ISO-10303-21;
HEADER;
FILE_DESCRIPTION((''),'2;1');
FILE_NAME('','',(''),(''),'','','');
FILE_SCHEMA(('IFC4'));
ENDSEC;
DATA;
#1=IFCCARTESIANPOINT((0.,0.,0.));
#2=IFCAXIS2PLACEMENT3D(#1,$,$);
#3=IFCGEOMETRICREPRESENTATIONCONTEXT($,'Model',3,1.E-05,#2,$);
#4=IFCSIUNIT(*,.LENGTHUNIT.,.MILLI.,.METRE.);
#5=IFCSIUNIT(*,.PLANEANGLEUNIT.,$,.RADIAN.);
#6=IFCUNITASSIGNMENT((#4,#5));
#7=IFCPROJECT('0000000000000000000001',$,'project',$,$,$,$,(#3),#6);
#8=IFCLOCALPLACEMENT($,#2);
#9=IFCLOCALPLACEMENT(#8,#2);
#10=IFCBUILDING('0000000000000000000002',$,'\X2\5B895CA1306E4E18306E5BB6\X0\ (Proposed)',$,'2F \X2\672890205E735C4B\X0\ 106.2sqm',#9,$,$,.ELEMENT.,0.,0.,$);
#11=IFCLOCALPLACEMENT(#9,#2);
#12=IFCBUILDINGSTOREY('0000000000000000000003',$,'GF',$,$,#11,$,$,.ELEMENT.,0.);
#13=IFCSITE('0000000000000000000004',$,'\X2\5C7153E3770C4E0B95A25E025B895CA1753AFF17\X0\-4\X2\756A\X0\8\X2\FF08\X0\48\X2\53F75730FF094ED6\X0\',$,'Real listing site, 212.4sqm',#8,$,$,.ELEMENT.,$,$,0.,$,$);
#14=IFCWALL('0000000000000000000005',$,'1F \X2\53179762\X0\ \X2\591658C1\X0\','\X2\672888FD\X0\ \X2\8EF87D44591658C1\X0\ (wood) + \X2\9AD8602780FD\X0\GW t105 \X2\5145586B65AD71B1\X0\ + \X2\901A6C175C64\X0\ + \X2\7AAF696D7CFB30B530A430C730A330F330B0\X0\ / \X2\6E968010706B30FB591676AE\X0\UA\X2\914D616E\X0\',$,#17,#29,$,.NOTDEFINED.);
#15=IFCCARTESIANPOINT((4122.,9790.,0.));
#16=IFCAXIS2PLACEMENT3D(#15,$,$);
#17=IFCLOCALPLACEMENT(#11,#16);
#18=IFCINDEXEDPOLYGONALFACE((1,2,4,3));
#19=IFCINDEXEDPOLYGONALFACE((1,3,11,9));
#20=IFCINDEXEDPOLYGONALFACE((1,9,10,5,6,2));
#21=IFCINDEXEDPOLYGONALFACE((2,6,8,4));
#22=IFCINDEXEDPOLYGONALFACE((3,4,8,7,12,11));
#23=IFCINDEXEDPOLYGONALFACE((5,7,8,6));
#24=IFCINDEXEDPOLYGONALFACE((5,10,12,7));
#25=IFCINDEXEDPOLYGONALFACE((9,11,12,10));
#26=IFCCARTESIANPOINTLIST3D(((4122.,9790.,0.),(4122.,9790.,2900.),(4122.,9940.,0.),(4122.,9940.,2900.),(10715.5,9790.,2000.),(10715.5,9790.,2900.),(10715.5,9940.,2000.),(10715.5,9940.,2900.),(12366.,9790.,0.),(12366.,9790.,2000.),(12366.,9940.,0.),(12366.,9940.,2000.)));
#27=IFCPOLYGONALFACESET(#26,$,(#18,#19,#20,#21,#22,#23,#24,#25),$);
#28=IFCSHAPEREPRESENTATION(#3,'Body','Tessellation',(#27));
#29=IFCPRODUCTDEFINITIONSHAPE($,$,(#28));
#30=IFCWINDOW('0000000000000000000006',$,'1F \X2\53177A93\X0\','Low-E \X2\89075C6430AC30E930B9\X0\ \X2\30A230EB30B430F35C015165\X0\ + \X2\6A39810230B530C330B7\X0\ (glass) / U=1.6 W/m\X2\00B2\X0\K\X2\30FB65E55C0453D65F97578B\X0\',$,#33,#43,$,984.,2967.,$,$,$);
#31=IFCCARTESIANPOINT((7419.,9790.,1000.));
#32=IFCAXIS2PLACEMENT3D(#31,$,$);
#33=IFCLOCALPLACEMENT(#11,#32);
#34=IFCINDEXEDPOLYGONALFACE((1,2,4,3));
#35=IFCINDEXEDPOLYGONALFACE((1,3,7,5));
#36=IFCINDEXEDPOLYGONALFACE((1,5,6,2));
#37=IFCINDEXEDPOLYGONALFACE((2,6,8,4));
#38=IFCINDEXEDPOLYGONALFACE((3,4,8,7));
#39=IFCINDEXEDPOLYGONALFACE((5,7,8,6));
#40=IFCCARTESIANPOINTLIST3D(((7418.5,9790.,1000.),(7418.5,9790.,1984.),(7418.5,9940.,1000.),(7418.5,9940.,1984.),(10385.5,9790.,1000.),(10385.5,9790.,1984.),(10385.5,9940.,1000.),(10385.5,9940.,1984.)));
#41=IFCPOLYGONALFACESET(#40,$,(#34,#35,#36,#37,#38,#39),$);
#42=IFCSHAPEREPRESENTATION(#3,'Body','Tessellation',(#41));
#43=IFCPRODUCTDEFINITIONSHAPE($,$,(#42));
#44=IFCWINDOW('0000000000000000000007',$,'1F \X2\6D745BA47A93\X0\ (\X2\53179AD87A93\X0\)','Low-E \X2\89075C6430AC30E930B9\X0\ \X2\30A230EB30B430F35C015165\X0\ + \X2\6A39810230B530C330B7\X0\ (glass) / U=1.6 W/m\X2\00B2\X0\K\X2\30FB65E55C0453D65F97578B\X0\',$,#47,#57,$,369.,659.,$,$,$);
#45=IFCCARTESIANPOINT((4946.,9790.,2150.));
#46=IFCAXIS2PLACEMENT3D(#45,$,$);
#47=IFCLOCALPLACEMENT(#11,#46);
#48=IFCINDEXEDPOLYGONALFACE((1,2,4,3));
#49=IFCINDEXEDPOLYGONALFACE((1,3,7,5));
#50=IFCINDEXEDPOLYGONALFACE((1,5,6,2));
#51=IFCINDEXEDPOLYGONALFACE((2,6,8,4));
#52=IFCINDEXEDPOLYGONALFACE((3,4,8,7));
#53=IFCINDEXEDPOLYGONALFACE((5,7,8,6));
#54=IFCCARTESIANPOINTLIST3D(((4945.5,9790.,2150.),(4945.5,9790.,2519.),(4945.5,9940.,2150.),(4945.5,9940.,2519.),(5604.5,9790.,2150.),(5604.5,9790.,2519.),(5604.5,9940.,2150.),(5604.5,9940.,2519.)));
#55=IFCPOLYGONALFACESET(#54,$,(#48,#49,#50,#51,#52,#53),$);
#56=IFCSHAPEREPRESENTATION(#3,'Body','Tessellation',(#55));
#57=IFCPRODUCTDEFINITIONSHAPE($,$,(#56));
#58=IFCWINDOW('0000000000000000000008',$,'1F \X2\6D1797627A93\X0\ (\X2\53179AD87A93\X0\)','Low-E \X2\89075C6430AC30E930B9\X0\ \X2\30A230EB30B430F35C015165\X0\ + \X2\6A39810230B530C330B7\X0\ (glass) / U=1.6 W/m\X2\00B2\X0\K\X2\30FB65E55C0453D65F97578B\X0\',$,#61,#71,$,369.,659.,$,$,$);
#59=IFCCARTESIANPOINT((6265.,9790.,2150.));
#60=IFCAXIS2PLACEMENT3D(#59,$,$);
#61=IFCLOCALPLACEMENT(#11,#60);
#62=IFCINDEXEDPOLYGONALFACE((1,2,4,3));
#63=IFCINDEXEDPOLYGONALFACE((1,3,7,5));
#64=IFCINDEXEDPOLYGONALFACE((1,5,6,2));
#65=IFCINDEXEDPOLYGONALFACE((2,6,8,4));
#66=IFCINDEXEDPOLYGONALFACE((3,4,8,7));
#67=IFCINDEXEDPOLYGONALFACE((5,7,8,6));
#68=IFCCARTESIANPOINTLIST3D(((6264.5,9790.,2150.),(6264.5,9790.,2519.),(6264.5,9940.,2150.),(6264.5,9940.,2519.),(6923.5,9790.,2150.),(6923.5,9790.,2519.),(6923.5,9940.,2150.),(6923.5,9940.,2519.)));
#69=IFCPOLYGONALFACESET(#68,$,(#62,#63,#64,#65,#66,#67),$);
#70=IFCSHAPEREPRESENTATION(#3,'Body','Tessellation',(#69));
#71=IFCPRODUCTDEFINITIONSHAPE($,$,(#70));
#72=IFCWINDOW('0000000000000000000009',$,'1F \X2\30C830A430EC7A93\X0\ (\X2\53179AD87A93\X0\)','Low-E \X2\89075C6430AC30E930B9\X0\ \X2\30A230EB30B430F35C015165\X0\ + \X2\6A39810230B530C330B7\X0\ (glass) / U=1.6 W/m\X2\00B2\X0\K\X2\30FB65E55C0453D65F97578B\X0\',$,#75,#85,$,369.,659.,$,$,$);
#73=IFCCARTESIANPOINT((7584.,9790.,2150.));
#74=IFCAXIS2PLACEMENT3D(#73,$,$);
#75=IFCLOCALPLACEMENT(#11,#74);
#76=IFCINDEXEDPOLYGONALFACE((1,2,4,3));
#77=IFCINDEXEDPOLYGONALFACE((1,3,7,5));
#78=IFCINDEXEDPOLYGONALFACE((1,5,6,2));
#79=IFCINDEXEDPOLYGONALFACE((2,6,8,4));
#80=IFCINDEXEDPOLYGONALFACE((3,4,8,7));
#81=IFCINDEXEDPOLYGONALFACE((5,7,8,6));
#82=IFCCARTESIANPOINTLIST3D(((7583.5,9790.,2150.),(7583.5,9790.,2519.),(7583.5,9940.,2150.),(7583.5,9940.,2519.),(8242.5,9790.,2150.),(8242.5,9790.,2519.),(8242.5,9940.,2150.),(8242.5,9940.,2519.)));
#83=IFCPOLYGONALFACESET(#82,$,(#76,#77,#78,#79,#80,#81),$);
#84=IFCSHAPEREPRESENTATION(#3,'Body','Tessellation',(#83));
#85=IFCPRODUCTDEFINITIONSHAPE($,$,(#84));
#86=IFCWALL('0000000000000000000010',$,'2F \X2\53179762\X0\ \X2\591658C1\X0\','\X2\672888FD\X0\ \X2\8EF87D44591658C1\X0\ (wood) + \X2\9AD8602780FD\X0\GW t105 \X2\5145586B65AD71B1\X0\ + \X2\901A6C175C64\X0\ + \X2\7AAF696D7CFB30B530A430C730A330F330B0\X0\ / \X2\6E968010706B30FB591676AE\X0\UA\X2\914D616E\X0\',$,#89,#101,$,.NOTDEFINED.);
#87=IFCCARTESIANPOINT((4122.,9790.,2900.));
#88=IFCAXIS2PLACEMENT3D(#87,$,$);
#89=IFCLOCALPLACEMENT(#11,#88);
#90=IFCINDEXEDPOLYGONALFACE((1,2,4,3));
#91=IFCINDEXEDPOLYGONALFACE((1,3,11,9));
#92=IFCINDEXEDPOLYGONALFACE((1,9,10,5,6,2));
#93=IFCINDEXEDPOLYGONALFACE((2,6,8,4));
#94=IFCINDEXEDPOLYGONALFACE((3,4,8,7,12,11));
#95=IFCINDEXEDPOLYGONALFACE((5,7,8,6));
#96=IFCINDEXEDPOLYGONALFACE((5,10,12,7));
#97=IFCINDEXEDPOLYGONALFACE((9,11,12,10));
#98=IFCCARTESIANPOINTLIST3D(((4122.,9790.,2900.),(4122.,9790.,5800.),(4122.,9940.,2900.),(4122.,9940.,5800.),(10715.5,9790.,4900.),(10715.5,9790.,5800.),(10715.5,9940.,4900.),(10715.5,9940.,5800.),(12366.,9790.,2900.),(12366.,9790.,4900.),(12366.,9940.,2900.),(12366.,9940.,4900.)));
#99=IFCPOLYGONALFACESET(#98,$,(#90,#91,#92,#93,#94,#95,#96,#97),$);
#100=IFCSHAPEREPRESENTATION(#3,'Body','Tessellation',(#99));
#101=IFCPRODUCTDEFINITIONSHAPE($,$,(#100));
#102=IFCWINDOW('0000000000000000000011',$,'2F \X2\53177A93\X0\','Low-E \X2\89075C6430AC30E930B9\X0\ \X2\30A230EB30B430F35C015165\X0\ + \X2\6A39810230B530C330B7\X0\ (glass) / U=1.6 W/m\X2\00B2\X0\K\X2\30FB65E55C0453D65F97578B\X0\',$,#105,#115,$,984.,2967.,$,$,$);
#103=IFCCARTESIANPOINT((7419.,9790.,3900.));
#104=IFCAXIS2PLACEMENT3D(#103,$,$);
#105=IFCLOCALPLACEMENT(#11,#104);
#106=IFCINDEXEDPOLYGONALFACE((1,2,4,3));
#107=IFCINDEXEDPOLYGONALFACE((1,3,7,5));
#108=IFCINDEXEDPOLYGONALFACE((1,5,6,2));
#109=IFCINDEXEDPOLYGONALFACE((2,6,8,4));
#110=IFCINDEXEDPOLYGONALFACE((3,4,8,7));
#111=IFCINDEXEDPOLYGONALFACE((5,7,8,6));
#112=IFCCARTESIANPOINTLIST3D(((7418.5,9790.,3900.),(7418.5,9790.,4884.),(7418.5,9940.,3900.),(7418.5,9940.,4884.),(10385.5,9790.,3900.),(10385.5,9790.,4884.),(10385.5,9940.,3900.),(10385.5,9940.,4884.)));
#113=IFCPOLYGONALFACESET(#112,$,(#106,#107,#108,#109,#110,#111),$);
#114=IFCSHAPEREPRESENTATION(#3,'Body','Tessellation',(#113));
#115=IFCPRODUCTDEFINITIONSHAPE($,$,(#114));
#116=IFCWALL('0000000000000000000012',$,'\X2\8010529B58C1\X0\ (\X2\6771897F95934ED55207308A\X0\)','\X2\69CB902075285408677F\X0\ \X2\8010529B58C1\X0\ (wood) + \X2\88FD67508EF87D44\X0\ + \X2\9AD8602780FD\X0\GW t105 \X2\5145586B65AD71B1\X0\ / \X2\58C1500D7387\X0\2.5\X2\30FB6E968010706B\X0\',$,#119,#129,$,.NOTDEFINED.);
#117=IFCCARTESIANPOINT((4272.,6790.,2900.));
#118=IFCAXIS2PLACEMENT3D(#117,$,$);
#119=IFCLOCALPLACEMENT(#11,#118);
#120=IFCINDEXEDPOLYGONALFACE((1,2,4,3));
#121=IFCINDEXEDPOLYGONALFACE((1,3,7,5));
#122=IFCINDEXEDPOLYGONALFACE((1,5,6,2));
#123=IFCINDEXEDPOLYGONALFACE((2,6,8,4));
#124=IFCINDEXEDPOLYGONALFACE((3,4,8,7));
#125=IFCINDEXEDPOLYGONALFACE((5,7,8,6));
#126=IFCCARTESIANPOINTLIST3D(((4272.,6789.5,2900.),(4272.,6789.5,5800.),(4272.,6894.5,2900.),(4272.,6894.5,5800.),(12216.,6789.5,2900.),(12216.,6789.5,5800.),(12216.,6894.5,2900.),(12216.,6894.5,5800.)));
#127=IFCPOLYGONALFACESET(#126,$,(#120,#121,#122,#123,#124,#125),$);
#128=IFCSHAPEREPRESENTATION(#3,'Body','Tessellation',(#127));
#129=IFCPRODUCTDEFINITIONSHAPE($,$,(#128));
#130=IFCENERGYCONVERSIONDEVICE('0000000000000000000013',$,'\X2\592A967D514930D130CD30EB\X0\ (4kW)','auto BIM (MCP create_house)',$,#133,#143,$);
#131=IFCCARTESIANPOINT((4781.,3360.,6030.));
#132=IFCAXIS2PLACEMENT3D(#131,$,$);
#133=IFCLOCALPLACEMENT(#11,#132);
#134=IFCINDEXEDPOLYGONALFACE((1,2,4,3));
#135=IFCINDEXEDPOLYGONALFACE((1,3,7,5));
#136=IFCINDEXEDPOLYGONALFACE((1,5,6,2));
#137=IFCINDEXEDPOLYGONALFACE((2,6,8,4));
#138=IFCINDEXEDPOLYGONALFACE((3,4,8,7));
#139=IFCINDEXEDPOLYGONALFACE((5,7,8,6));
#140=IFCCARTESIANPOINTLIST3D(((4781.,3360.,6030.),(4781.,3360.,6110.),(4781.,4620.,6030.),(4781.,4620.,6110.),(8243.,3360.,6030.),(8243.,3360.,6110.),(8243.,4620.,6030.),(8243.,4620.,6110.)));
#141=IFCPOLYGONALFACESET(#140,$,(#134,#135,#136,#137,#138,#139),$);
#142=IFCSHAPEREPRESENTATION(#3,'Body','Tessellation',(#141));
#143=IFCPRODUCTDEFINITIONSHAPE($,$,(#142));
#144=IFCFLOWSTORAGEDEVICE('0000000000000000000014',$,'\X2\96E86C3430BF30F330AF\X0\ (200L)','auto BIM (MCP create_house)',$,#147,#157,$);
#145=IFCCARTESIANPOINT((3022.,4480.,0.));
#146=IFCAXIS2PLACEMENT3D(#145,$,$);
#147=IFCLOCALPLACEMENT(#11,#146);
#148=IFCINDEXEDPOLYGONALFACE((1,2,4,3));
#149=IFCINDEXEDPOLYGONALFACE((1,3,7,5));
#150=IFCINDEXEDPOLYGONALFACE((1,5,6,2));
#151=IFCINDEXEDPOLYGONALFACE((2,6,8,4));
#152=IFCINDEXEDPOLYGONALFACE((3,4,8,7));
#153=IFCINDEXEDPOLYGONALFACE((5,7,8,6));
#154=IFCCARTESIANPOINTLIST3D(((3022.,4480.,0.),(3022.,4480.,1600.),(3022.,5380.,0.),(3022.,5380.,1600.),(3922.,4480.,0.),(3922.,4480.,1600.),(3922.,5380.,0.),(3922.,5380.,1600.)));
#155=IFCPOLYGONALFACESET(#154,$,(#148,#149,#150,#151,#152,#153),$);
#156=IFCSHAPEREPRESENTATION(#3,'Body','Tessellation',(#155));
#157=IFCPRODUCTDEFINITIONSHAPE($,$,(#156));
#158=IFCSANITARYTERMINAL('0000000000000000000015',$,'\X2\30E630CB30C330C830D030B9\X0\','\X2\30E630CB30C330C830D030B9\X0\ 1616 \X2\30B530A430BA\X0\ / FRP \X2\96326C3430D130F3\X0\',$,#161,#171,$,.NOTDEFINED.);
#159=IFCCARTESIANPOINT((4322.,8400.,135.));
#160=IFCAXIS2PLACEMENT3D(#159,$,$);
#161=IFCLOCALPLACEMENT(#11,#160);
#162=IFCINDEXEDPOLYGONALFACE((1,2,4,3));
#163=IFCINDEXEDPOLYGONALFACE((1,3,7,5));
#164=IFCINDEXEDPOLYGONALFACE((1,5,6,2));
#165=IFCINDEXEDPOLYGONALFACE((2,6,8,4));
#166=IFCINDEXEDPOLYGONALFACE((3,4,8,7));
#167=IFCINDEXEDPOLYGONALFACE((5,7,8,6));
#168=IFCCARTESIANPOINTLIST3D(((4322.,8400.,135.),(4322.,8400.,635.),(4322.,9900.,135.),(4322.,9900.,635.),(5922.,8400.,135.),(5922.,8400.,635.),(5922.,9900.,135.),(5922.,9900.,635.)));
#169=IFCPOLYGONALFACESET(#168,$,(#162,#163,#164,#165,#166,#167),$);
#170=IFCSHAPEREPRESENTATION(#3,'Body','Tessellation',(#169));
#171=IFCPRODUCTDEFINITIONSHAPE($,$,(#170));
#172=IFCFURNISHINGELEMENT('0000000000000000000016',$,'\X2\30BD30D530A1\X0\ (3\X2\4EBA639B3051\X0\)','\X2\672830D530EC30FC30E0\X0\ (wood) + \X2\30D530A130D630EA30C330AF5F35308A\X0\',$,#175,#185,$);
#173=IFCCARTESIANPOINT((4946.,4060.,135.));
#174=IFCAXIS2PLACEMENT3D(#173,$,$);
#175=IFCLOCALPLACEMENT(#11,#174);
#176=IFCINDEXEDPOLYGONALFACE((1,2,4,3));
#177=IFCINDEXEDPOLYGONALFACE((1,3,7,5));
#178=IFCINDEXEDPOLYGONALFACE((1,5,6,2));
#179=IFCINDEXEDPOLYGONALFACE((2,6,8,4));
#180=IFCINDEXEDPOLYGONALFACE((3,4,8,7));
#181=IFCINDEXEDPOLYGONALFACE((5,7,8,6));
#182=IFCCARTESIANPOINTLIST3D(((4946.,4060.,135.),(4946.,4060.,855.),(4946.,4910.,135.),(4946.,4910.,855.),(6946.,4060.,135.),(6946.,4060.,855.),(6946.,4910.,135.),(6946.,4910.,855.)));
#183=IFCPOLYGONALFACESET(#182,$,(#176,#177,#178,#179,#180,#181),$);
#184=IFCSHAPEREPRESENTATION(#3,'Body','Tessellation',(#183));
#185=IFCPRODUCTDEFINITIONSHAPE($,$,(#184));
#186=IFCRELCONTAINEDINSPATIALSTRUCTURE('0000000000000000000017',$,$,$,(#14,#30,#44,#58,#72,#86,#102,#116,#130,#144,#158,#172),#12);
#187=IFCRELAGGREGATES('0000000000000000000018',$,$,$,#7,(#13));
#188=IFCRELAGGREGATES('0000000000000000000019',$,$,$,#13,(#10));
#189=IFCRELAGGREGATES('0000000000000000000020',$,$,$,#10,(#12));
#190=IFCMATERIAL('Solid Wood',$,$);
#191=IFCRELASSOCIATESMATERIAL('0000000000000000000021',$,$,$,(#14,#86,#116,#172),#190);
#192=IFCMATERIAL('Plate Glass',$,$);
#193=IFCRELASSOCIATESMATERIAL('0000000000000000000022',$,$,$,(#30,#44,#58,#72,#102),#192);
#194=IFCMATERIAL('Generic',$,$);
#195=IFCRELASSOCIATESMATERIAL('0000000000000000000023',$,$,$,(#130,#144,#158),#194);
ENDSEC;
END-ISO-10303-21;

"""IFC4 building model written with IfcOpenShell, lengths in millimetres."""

from ifc_helpers import new_model, si_unit, frame, frame_2d, origin, place, context, project, spatial, rectangle, extrude, material, element, fill, save


model = new_model("IFC4")

# Units and contexts
model_context = context("Model", 3, precision=1e-05, world=origin())
ifc_project = project(units=[si_unit("LENGTHUNIT", "METRE", prefix="MILLI"), si_unit("PLANEANGLEUNIT", "RADIAN")], contexts=[model_context])

# Site, building, storey
site_placement = place(None, origin())
site = spatial("IfcSite", under=ifc_project, at=site_placement, Name="山口県下関市安岡町７-4番8（48号地）他", ObjectType="Real listing site, 212.4sqm", CompositionType="ELEMENT", RefElevation=0.0)
building_placement = place(site_placement, origin())
building = spatial("IfcBuilding", under=site, at=building_placement, Name="安岡の丘の家 (Proposed)", ObjectType="2F 木造平屋 106.2sqm", CompositionType="ELEMENT", ElevationOfRefHeight=0.0, ElevationOfTerrain=0.0)
storey_placement = place(building_placement, origin())
storey = spatial("IfcBuildingStorey", under=building, at=storey_placement, Name="GF", CompositionType="ELEMENT", Elevation=0.0)

# Wall, openings, windows
ifc_material_1 = material(Name="Solid Wood")
wall_1_placement = place(storey_placement, frame((4122.0, 9790.0, 0.0)))
wall_1 = element("IfcWall", 1, at=wall_1_placement, inside=storey, material=ifc_material_1, Name="1F 北面 外壁", Description="木製 軸組外壁 (wood) + 高性能GW t105 充填断熱 + 通気層 + 窯業系サイディング / 準耐火・外皮UA配慮", PredefinedType="NOTDEFINED", context=model_context, shape_type="SweptSolid", body=[
    extrude(rectangle(XDim=8244.0, YDim=150.0, at=frame_2d((4122.0, 75.0))), frame((4122.0, 9790.0, 0.0)), (0.0, 0.0, 1.0), 2900.0),
])
opening_1_placement = place(storey_placement, frame((7419.0, 9790.0, 1000.0)))
opening_1 = element("IfcOpeningElement", 2, at=opening_1_placement, cuts=wall_1, PredefinedType="NOTDEFINED", context=model_context, shape_type="SweptSolid", body=[
    extrude(rectangle(XDim=2967.0, YDim=150.0, at=frame_2d((1483.0, 75.0))), frame((7419.0, 9790.0, 1000.0)), (0.0, 0.0, 1.0), 984.0),
])
opening_2_placement = place(storey_placement, frame((4946.0, 9790.0, 2150.0)))
opening_2 = element("IfcOpeningElement", 3, at=opening_2_placement, cuts=wall_1, PredefinedType="NOTDEFINED", context=model_context, shape_type="SweptSolid", body=[
    extrude(rectangle(XDim=659.0, YDim=150.0, at=frame_2d((329.0, 75.0))), frame((4946.0, 9790.0, 2150.0)), (0.0, 0.0, 1.0), 369.0),
])
opening_3_placement = place(storey_placement, frame((6265.0, 9790.0, 2150.0)))
opening_3 = element("IfcOpeningElement", 4, at=opening_3_placement, cuts=wall_1, PredefinedType="NOTDEFINED", context=model_context, shape_type="SweptSolid", body=[
    extrude(rectangle(XDim=659.0, YDim=150.0, at=frame_2d((329.0, 75.0))), frame((6265.0, 9790.0, 2150.0)), (0.0, 0.0, 1.0), 369.0),
])
opening_4_placement = place(storey_placement, frame((7584.0, 9790.0, 2150.0)))
opening_4 = element("IfcOpeningElement", 5, at=opening_4_placement, cuts=wall_1, PredefinedType="NOTDEFINED", context=model_context, shape_type="SweptSolid", body=[
    extrude(rectangle(XDim=659.0, YDim=150.0, at=frame_2d((329.0, 75.0))), frame((7584.0, 9790.0, 2150.0)), (0.0, 0.0, 1.0), 369.0),
])
ifc_material_2 = material(Name="Plate Glass")
window_1_placement = place(storey_placement, frame((7419.0, 9790.0, 1000.0)))
window_1 = element("IfcWindow", 6, at=window_1_placement, inside=storey, material=ifc_material_2, Name="1F 北窓", Description="Low-E 複層ガラス アルゴン封入 + 樹脂サッシ (glass) / U=1.6 W/m²K・日射取得型", OverallHeight=984.0, OverallWidth=2967.0, context=model_context, shape_type="SweptSolid", body=[
    extrude(rectangle(XDim=2967.0, YDim=150.0, at=frame_2d((1483.0, 75.0))), frame((7419.0, 9790.0, 1000.0)), (0.0, 0.0, 1.0), 984.0),
])
fill(opening_1, window_1)
window_2_placement = place(storey_placement, frame((4946.0, 9790.0, 2150.0)))
window_2 = element("IfcWindow", 7, at=window_2_placement, inside=storey, material=ifc_material_2, Name="1F 浴室窓 (北高窓)", Description="Low-E 複層ガラス アルゴン封入 + 樹脂サッシ (glass) / U=1.6 W/m²K・日射取得型", OverallHeight=369.0, OverallWidth=659.0, context=model_context, shape_type="SweptSolid", body=[
    extrude(rectangle(XDim=659.0, YDim=150.0, at=frame_2d((329.0, 75.0))), frame((4946.0, 9790.0, 2150.0)), (0.0, 0.0, 1.0), 369.0),
])
fill(opening_2, window_2)
window_3_placement = place(storey_placement, frame((6265.0, 9790.0, 2150.0)))
window_3 = element("IfcWindow", 8, at=window_3_placement, inside=storey, material=ifc_material_2, Name="1F 洗面窓 (北高窓)", Description="Low-E 複層ガラス アルゴン封入 + 樹脂サッシ (glass) / U=1.6 W/m²K・日射取得型", OverallHeight=369.0, OverallWidth=659.0, context=model_context, shape_type="SweptSolid", body=[
    extrude(rectangle(XDim=659.0, YDim=150.0, at=frame_2d((329.0, 75.0))), frame((6265.0, 9790.0, 2150.0)), (0.0, 0.0, 1.0), 369.0),
])
fill(opening_3, window_3)
window_4_placement = place(storey_placement, frame((7584.0, 9790.0, 2150.0)))
window_4 = element("IfcWindow", 9, at=window_4_placement, inside=storey, material=ifc_material_2, Name="1F トイレ窓 (北高窓)", Description="Low-E 複層ガラス アルゴン封入 + 樹脂サッシ (glass) / U=1.6 W/m²K・日射取得型", OverallHeight=369.0, OverallWidth=659.0, context=model_context, shape_type="SweptSolid", body=[
    extrude(rectangle(XDim=659.0, YDim=150.0, at=frame_2d((329.0, 75.0))), frame((7584.0, 9790.0, 2150.0)), (0.0, 0.0, 1.0), 369.0),
])
fill(opening_4, window_4)

# Wall, opening, window
wall_2_placement = place(storey_placement, frame((4122.0, 9790.0, 2900.0)))
wall_2 = element("IfcWall", 10, at=wall_2_placement, inside=storey, material=ifc_material_1, Name="2F 北面 外壁", Description="木製 軸組外壁 (wood) + 高性能GW t105 充填断熱 + 通気層 + 窯業系サイディング / 準耐火・外皮UA配慮", PredefinedType="NOTDEFINED", context=model_context, shape_type="SweptSolid", body=[
    extrude(rectangle(XDim=8244.0, YDim=150.0, at=frame_2d((4122.0, 75.0))), frame((4122.0, 9790.0, 2900.0)), (0.0, 0.0, 1.0), 2900.0),
])
opening_5_placement = place(storey_placement, frame((7419.0, 9790.0, 3900.0)))
opening_5 = element("IfcOpeningElement", 11, at=opening_5_placement, cuts=wall_2, PredefinedType="NOTDEFINED", context=model_context, shape_type="SweptSolid", body=[
    extrude(rectangle(XDim=2967.0, YDim=150.0, at=frame_2d((1483.0, 75.0))), frame((7419.0, 9790.0, 3900.0)), (0.0, 0.0, 1.0), 984.0),
])
window_5_placement = place(storey_placement, frame((7419.0, 9790.0, 3900.0)))
window_5 = element("IfcWindow", 12, at=window_5_placement, inside=storey, material=ifc_material_2, Name="2F 北窓", Description="Low-E 複層ガラス アルゴン封入 + 樹脂サッシ (glass) / U=1.6 W/m²K・日射取得型", OverallHeight=984.0, OverallWidth=2967.0, context=model_context, shape_type="SweptSolid", body=[
    extrude(rectangle(XDim=2967.0, YDim=150.0, at=frame_2d((1483.0, 75.0))), frame((7419.0, 9790.0, 3900.0)), (0.0, 0.0, 1.0), 984.0),
])
fill(opening_5, window_5)

# Wall
wall_3_placement = place(storey_placement, frame((4272.0, 6790.0, 2900.0)))
element("IfcWall", 13, at=wall_3_placement, inside=storey, material=ifc_material_1, Name="耐力壁 (東西間仕切り)", Description="構造用合板 耐力壁 (wood) + 製材軸組 + 高性能GW t105 充填断熱 / 壁倍率2.5・準耐火", PredefinedType="NOTDEFINED", context=model_context, shape_type="SweptSolid", body=[
    extrude(rectangle(XDim=7944.0, YDim=105.0, at=frame_2d((3972.0, 52.0))), frame((4272.0, 6790.0, 2900.0)), (0.0, 0.0, 1.0), 2900.0),
])

# Energy conversion device
ifc_material_3 = material(Name="Generic")
energy_conversion_device_placement = place(storey_placement, frame((4781.0, 3360.0, 6030.0)))
element("IfcEnergyConversionDevice", 14, at=energy_conversion_device_placement, inside=storey, material=ifc_material_3, Name="太陽光パネル (4kW)", Description="auto BIM (MCP create_house)", context=model_context, shape_type="SweptSolid", body=[
    extrude(rectangle(XDim=3462.0, YDim=1260.0, at=frame_2d((1731.0, 630.0))), frame((4781.0, 3360.0, 6030.0)), (0.0, 0.0, 1.0), 80.0),
])

# Flow storage device
flow_storage_device_placement = place(storey_placement, frame((3022.0, 4480.0, 0.0)))
element("IfcFlowStorageDevice", 15, at=flow_storage_device_placement, inside=storey, material=ifc_material_3, Name="雨水タンク (200L)", Description="auto BIM (MCP create_house)", context=model_context, shape_type="SweptSolid", body=[
    extrude(rectangle(XDim=900.0, YDim=900.0, at=frame_2d((450.0, 450.0))), frame((3022.0, 4480.0, 0.0)), (0.0, 0.0, 1.0), 1600.0),
])

# Sanitary terminal
sanitary_terminal_placement = place(storey_placement, frame((4322.0, 8400.0, 135.0)))
element("IfcSanitaryTerminal", 16, at=sanitary_terminal_placement, inside=storey, material=ifc_material_3, Name="ユニットバス", Description="ユニットバス 1616 サイズ / FRP 防水パン", PredefinedType="NOTDEFINED", context=model_context, shape_type="SweptSolid", body=[
    extrude(rectangle(XDim=1600.0, YDim=1500.0, at=frame_2d((800.0, 750.0))), frame((4322.0, 8400.0, 135.0)), (0.0, 0.0, 1.0), 500.0),
])

# Furnishing element
furnishing_1_placement = place(storey_placement, frame((4946.0, 4060.0, 135.0)))
element("IfcFurnishingElement", 17, at=furnishing_1_placement, inside=storey, material=ifc_material_1, Name="ソファ (3人掛け)", Description="木フレーム (wood) + ファブリック張り", context=model_context, shape_type="SweptSolid", body=[
    extrude(rectangle(XDim=2000.0, YDim=850.0, at=frame_2d((1000.0, 425.0))), frame((4946.0, 4060.0, 135.0)), (0.0, 0.0, 1.0), 720.0),
])

save(model, "model.ifc")
